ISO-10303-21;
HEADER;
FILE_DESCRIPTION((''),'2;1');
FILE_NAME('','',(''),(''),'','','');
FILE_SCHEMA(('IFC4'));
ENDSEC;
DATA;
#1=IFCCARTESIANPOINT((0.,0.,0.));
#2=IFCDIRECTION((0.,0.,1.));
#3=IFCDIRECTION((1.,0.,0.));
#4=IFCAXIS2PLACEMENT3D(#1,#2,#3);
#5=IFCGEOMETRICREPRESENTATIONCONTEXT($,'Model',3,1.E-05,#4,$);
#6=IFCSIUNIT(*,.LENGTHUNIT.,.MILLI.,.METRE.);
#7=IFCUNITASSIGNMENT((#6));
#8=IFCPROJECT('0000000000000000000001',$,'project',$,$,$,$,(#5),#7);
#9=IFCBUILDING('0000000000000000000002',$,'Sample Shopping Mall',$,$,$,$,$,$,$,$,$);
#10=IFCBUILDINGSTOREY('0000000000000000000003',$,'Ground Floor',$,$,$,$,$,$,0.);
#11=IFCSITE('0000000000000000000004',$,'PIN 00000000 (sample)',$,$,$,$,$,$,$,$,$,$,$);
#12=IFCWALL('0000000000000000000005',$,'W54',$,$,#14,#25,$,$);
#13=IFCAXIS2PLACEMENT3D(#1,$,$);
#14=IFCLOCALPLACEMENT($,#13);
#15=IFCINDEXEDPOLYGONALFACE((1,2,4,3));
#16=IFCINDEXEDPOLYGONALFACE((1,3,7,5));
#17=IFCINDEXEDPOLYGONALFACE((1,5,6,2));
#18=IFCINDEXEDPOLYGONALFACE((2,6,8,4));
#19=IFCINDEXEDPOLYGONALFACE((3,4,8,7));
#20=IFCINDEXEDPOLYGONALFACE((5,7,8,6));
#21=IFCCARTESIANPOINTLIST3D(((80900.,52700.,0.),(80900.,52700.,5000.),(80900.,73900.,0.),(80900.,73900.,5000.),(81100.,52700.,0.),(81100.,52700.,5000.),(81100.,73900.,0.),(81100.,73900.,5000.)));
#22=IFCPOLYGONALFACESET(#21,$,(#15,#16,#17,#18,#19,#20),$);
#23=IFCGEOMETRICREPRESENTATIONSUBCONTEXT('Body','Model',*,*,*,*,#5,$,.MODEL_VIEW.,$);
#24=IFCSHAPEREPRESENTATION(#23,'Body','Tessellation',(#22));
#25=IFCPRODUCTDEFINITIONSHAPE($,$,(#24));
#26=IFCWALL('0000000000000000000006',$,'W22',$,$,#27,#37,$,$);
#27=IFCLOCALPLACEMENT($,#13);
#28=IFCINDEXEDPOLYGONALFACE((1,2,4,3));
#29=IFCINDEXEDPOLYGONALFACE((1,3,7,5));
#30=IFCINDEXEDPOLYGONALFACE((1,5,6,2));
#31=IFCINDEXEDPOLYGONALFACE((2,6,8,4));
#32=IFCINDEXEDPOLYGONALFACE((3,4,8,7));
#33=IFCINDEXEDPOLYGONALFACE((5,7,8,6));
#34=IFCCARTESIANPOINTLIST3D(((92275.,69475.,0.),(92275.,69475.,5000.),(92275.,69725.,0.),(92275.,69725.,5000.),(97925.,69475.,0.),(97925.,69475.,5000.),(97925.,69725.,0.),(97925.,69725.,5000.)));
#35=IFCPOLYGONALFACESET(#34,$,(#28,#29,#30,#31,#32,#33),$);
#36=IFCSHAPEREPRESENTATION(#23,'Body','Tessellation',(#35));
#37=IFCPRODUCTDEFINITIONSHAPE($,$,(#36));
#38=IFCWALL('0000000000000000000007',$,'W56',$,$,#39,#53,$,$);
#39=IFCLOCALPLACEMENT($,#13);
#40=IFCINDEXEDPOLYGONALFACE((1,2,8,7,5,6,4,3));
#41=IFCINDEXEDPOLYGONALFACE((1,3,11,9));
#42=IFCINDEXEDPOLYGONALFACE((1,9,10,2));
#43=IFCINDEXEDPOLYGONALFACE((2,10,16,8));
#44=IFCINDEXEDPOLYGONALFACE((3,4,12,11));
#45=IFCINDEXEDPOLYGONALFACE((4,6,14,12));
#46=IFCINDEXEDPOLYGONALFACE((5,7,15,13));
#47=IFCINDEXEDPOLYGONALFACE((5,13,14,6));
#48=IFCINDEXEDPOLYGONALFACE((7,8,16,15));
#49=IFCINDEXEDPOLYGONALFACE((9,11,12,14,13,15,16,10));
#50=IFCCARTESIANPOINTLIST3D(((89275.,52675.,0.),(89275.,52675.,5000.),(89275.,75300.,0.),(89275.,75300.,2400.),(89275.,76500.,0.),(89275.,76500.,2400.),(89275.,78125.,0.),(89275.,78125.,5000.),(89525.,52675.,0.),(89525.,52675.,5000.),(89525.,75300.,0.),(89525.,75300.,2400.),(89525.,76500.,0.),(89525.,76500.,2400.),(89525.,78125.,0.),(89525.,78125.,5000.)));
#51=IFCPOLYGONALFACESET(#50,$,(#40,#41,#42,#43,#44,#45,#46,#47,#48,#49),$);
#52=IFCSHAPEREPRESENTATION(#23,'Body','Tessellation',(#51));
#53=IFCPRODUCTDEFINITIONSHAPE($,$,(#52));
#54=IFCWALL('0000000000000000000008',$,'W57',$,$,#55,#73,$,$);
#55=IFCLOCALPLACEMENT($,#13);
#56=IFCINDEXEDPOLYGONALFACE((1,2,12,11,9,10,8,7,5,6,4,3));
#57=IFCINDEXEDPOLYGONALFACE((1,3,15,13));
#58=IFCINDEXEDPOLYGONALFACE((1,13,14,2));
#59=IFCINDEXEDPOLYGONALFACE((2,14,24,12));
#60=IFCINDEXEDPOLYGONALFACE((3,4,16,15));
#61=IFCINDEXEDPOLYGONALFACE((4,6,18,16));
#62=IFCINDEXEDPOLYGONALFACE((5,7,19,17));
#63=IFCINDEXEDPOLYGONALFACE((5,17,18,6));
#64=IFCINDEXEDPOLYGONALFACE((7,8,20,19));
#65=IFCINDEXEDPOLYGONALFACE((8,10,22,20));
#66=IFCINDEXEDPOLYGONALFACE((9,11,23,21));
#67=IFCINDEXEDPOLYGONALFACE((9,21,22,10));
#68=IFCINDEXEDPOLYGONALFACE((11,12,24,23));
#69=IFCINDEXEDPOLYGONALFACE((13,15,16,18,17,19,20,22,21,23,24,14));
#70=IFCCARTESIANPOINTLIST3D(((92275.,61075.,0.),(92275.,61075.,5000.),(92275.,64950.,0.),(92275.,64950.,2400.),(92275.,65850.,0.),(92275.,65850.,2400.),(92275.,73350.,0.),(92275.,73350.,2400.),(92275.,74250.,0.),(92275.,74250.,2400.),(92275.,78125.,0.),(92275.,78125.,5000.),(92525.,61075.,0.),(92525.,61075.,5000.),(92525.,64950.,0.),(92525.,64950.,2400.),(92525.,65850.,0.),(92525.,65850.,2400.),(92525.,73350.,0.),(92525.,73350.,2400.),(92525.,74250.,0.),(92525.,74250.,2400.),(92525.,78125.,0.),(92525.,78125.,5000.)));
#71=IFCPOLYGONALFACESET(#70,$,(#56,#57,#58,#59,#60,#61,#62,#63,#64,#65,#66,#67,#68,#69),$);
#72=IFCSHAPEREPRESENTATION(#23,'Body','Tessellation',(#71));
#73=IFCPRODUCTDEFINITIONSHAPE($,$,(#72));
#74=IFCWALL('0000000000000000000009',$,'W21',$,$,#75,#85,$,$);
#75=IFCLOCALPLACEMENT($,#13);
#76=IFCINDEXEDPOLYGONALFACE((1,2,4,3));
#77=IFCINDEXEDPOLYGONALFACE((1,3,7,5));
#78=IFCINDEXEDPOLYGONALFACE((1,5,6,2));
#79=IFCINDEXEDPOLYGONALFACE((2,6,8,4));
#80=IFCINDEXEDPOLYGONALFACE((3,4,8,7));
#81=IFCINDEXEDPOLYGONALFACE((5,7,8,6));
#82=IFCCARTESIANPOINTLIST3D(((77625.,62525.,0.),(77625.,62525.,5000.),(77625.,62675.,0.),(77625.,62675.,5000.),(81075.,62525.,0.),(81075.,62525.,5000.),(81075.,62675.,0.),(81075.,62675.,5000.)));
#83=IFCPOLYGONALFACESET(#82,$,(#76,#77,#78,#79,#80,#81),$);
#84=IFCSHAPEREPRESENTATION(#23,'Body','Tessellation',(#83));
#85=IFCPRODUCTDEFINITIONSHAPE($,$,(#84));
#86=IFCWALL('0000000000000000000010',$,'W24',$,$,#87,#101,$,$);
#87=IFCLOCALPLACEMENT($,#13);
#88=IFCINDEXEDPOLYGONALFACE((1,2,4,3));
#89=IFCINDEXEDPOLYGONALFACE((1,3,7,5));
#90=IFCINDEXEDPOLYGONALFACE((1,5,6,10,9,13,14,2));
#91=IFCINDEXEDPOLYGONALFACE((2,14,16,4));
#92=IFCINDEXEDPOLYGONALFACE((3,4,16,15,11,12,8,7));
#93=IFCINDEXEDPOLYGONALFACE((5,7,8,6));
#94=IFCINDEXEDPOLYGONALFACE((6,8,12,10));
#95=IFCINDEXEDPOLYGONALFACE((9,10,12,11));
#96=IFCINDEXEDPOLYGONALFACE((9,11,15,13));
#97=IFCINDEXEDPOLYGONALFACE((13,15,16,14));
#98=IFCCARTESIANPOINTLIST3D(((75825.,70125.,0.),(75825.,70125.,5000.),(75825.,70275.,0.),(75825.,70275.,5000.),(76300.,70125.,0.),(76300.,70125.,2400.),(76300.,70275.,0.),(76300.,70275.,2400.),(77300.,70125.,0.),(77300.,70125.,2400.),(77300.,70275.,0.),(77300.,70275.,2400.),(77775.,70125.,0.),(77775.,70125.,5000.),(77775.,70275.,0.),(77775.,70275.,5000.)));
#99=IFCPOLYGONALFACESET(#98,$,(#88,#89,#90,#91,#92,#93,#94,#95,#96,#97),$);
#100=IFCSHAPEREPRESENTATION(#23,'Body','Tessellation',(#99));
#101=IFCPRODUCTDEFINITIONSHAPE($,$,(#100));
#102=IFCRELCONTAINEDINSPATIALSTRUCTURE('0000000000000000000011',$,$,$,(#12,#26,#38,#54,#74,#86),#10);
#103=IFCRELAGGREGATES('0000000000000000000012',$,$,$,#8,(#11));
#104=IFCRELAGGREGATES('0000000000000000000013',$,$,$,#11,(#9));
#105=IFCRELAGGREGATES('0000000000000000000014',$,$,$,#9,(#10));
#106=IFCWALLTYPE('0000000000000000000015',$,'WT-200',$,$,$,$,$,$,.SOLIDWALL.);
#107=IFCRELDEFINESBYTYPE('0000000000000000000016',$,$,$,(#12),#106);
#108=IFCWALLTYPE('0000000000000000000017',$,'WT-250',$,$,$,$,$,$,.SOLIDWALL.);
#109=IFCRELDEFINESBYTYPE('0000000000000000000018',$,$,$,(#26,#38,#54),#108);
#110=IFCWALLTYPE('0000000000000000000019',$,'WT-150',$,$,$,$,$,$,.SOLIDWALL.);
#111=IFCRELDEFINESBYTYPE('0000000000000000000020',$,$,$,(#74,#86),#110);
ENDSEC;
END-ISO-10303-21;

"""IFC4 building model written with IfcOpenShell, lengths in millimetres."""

from ifc_helpers import new_model, si_unit, frame, origin_with_axes, place, context, subcontext, project, spatial, indexed_curve, outline, extrude, type_object, element, save


model = new_model("IFC4")

# Units and contexts
model_context = context("Model", 3, precision=1e-05, world=origin_with_axes())
body_context = subcontext(model_context, "Body", "Model", "MODEL_VIEW")
ifc_project = project(units=[si_unit("LENGTHUNIT", "METRE", prefix="MILLI")], contexts=[model_context])

# Site, building, storey
site = spatial("IfcSite", under=ifc_project, Name="PIN 00000000 (sample)")
building = spatial("IfcBuilding", under=site, Name="Sample Shopping Mall")
storey = spatial("IfcBuildingStorey", under=building, Name="Ground Floor", Elevation=0.0)

# Wall
wall_type_1 = type_object("IfcWallType", Name="WT-200", PredefinedType="SOLIDWALL")
wall_1_placement = place(None, frame((81100.0, 52700.0, 0.0), z_axis=(0.0, 0.0, 1.0), x_axis=(0.0, 1.0, 0.0)))
element("IfcWall", 1, at=wall_1_placement, inside=storey, type_object=wall_type_1, Name="W54", context=body_context, shape_type="SweptSolid", body=[
    extrude(outline(indexed_curve([(0.0, 0.0), (0.0, 200.0), (21200.0, 200.0), (21200.0, 0.0), (0.0, 0.0)], self_intersect=False)), origin_with_axes(), (0.0, 0.0, 1.0), 5000.0),
])

# Shared definitions
wall_type_2 = type_object("IfcWallType", Name="WT-250", PredefinedType="SOLIDWALL")

# Wall
wall_2_placement = place(None, frame((92275.0, 69475.0, 0.0), z_axis=(0.0, 0.0, 1.0), x_axis=(1.0, 0.0, 0.0)))
element("IfcWall", 2, at=wall_2_placement, inside=storey, type_object=wall_type_2, Name="W22", context=body_context, shape_type="SweptSolid", body=[
    extrude(outline(indexed_curve([(0.0, 0.0), (0.0, 250.0), (5650.0, 250.0), (5650.0, 0.0), (0.0, 0.0)], self_intersect=False)), origin_with_axes(), (0.0, 0.0, 1.0), 5000.0),
])

# Wall, opening
wall_3_placement = place(None, frame((89525.0, 52675.0, 0.0), z_axis=(0.0, 0.0, 1.0), x_axis=(0.0, 1.0, 0.0)))
wall_3 = element("IfcWall", 3, at=wall_3_placement, inside=storey, type_object=wall_type_2, Name="W56", context=body_context, shape_type="SweptSolid", body=[
    extrude(outline(indexed_curve([(0.0, 0.0), (0.0, 250.0), (25450.0, 250.0), (25450.0, 0.0), (0.0, 0.0)], self_intersect=False)), origin_with_axes(), (0.0, 0.0, 1.0), 5000.0),
])
opening_1_placement = place(wall_3_placement, frame((22625.0, -100.0, 0.0), z_axis=(0.0, 0.0, 1.0), x_axis=(1.0, 0.0, 0.0)))
element("IfcOpeningElement", 4, at=opening_1_placement, cuts=wall_3, context=body_context, shape_type="SweptSolid", body=[
    extrude(outline(indexed_curve([(0.0, 0.0), (0.0, 450.0), (1200.0, 450.0), (1200.0, 0.0), (0.0, 0.0)], self_intersect=False)), origin_with_axes(), (0.0, 0.0, 1.0), 2400.0),
])

# Wall, openings
wall_4_placement = place(None, frame((92525.0, 61075.0, 0.0), z_axis=(0.0, 0.0, 1.0), x_axis=(0.0, 1.0, 0.0)))
wall_4 = element("IfcWall", 5, at=wall_4_placement, inside=storey, type_object=wall_type_2, Name="W57", context=body_context, shape_type="SweptSolid", body=[
    extrude(outline(indexed_curve([(0.0, 0.0), (0.0, 250.0), (17050.0, 250.0), (17050.0, 0.0), (0.0, 0.0)], self_intersect=False)), origin_with_axes(), (0.0, 0.0, 1.0), 5000.0),
])
opening_2_placement = place(wall_4_placement, frame((3875.0, -100.0, 0.0), z_axis=(0.0, 0.0, 1.0), x_axis=(1.0, 0.0, 0.0)))
element("IfcOpeningElement", 6, at=opening_2_placement, cuts=wall_4, context=body_context, shape_type="SweptSolid", body=[
    extrude(outline(indexed_curve([(0.0, 0.0), (0.0, 450.0), (900.0, 450.0), (900.0, 0.0), (0.0, 0.0)], self_intersect=False)), origin_with_axes(), (0.0, 0.0, 1.0), 2400.0),
])
opening_3_placement = place(wall_4_placement, frame((12275.0, -100.0, 0.0), z_axis=(0.0, 0.0, 1.0), x_axis=(1.0, 0.0, 0.0)))
element("IfcOpeningElement", 7, at=opening_3_placement, cuts=wall_4, context=body_context, shape_type="SweptSolid", body=[
    extrude(outline(indexed_curve([(0.0, 0.0), (0.0, 450.0), (900.0, 450.0), (900.0, 0.0), (0.0, 0.0)], self_intersect=False)), origin_with_axes(), (0.0, 0.0, 1.0), 2400.0),
])

# Wall
wall_type_3 = type_object("IfcWallType", Name="WT-150", PredefinedType="SOLIDWALL")
wall_5_placement = place(None, frame((77625.0, 62525.0, 0.0), z_axis=(0.0, 0.0, 1.0), x_axis=(1.0, 0.0, 0.0)))
element("IfcWall", 8, at=wall_5_placement, inside=storey, type_object=wall_type_3, Name="W21", context=body_context, shape_type="SweptSolid", body=[
    extrude(outline(indexed_curve([(0.0, 0.0), (0.0, 150.0), (3450.0, 150.0), (3450.0, 0.0), (0.0, 0.0)], self_intersect=False)), origin_with_axes(), (0.0, 0.0, 1.0), 5000.0),
])

# Wall, opening
wall_6_placement = place(None, frame((75825.0, 70125.0, 0.0), z_axis=(0.0, 0.0, 1.0), x_axis=(1.0, 0.0, 0.0)))
wall_6 = element("IfcWall", 9, at=wall_6_placement, inside=storey, type_object=wall_type_3, Name="W24", context=body_context, shape_type="SweptSolid", body=[
    extrude(outline(indexed_curve([(0.0, 0.0), (0.0, 150.0), (1950.0, 150.0), (1950.0, 0.0), (0.0, 0.0)], self_intersect=False)), origin_with_axes(), (0.0, 0.0, 1.0), 5000.0),
])
opening_4_placement = place(wall_6_placement, frame((475.0, -100.0, 0.0), z_axis=(0.0, 0.0, 1.0), x_axis=(1.0, 0.0, 0.0)))
element("IfcOpeningElement", 10, at=opening_4_placement, cuts=wall_6, context=body_context, shape_type="SweptSolid", body=[
    extrude(outline(indexed_curve([(0.0, 0.0), (0.0, 350.0), (1000.0, 350.0), (1000.0, 0.0), (0.0, 0.0)], self_intersect=False)), origin_with_axes(), (0.0, 0.0, 1.0), 2400.0),
])

save(model, "model.ifc")
